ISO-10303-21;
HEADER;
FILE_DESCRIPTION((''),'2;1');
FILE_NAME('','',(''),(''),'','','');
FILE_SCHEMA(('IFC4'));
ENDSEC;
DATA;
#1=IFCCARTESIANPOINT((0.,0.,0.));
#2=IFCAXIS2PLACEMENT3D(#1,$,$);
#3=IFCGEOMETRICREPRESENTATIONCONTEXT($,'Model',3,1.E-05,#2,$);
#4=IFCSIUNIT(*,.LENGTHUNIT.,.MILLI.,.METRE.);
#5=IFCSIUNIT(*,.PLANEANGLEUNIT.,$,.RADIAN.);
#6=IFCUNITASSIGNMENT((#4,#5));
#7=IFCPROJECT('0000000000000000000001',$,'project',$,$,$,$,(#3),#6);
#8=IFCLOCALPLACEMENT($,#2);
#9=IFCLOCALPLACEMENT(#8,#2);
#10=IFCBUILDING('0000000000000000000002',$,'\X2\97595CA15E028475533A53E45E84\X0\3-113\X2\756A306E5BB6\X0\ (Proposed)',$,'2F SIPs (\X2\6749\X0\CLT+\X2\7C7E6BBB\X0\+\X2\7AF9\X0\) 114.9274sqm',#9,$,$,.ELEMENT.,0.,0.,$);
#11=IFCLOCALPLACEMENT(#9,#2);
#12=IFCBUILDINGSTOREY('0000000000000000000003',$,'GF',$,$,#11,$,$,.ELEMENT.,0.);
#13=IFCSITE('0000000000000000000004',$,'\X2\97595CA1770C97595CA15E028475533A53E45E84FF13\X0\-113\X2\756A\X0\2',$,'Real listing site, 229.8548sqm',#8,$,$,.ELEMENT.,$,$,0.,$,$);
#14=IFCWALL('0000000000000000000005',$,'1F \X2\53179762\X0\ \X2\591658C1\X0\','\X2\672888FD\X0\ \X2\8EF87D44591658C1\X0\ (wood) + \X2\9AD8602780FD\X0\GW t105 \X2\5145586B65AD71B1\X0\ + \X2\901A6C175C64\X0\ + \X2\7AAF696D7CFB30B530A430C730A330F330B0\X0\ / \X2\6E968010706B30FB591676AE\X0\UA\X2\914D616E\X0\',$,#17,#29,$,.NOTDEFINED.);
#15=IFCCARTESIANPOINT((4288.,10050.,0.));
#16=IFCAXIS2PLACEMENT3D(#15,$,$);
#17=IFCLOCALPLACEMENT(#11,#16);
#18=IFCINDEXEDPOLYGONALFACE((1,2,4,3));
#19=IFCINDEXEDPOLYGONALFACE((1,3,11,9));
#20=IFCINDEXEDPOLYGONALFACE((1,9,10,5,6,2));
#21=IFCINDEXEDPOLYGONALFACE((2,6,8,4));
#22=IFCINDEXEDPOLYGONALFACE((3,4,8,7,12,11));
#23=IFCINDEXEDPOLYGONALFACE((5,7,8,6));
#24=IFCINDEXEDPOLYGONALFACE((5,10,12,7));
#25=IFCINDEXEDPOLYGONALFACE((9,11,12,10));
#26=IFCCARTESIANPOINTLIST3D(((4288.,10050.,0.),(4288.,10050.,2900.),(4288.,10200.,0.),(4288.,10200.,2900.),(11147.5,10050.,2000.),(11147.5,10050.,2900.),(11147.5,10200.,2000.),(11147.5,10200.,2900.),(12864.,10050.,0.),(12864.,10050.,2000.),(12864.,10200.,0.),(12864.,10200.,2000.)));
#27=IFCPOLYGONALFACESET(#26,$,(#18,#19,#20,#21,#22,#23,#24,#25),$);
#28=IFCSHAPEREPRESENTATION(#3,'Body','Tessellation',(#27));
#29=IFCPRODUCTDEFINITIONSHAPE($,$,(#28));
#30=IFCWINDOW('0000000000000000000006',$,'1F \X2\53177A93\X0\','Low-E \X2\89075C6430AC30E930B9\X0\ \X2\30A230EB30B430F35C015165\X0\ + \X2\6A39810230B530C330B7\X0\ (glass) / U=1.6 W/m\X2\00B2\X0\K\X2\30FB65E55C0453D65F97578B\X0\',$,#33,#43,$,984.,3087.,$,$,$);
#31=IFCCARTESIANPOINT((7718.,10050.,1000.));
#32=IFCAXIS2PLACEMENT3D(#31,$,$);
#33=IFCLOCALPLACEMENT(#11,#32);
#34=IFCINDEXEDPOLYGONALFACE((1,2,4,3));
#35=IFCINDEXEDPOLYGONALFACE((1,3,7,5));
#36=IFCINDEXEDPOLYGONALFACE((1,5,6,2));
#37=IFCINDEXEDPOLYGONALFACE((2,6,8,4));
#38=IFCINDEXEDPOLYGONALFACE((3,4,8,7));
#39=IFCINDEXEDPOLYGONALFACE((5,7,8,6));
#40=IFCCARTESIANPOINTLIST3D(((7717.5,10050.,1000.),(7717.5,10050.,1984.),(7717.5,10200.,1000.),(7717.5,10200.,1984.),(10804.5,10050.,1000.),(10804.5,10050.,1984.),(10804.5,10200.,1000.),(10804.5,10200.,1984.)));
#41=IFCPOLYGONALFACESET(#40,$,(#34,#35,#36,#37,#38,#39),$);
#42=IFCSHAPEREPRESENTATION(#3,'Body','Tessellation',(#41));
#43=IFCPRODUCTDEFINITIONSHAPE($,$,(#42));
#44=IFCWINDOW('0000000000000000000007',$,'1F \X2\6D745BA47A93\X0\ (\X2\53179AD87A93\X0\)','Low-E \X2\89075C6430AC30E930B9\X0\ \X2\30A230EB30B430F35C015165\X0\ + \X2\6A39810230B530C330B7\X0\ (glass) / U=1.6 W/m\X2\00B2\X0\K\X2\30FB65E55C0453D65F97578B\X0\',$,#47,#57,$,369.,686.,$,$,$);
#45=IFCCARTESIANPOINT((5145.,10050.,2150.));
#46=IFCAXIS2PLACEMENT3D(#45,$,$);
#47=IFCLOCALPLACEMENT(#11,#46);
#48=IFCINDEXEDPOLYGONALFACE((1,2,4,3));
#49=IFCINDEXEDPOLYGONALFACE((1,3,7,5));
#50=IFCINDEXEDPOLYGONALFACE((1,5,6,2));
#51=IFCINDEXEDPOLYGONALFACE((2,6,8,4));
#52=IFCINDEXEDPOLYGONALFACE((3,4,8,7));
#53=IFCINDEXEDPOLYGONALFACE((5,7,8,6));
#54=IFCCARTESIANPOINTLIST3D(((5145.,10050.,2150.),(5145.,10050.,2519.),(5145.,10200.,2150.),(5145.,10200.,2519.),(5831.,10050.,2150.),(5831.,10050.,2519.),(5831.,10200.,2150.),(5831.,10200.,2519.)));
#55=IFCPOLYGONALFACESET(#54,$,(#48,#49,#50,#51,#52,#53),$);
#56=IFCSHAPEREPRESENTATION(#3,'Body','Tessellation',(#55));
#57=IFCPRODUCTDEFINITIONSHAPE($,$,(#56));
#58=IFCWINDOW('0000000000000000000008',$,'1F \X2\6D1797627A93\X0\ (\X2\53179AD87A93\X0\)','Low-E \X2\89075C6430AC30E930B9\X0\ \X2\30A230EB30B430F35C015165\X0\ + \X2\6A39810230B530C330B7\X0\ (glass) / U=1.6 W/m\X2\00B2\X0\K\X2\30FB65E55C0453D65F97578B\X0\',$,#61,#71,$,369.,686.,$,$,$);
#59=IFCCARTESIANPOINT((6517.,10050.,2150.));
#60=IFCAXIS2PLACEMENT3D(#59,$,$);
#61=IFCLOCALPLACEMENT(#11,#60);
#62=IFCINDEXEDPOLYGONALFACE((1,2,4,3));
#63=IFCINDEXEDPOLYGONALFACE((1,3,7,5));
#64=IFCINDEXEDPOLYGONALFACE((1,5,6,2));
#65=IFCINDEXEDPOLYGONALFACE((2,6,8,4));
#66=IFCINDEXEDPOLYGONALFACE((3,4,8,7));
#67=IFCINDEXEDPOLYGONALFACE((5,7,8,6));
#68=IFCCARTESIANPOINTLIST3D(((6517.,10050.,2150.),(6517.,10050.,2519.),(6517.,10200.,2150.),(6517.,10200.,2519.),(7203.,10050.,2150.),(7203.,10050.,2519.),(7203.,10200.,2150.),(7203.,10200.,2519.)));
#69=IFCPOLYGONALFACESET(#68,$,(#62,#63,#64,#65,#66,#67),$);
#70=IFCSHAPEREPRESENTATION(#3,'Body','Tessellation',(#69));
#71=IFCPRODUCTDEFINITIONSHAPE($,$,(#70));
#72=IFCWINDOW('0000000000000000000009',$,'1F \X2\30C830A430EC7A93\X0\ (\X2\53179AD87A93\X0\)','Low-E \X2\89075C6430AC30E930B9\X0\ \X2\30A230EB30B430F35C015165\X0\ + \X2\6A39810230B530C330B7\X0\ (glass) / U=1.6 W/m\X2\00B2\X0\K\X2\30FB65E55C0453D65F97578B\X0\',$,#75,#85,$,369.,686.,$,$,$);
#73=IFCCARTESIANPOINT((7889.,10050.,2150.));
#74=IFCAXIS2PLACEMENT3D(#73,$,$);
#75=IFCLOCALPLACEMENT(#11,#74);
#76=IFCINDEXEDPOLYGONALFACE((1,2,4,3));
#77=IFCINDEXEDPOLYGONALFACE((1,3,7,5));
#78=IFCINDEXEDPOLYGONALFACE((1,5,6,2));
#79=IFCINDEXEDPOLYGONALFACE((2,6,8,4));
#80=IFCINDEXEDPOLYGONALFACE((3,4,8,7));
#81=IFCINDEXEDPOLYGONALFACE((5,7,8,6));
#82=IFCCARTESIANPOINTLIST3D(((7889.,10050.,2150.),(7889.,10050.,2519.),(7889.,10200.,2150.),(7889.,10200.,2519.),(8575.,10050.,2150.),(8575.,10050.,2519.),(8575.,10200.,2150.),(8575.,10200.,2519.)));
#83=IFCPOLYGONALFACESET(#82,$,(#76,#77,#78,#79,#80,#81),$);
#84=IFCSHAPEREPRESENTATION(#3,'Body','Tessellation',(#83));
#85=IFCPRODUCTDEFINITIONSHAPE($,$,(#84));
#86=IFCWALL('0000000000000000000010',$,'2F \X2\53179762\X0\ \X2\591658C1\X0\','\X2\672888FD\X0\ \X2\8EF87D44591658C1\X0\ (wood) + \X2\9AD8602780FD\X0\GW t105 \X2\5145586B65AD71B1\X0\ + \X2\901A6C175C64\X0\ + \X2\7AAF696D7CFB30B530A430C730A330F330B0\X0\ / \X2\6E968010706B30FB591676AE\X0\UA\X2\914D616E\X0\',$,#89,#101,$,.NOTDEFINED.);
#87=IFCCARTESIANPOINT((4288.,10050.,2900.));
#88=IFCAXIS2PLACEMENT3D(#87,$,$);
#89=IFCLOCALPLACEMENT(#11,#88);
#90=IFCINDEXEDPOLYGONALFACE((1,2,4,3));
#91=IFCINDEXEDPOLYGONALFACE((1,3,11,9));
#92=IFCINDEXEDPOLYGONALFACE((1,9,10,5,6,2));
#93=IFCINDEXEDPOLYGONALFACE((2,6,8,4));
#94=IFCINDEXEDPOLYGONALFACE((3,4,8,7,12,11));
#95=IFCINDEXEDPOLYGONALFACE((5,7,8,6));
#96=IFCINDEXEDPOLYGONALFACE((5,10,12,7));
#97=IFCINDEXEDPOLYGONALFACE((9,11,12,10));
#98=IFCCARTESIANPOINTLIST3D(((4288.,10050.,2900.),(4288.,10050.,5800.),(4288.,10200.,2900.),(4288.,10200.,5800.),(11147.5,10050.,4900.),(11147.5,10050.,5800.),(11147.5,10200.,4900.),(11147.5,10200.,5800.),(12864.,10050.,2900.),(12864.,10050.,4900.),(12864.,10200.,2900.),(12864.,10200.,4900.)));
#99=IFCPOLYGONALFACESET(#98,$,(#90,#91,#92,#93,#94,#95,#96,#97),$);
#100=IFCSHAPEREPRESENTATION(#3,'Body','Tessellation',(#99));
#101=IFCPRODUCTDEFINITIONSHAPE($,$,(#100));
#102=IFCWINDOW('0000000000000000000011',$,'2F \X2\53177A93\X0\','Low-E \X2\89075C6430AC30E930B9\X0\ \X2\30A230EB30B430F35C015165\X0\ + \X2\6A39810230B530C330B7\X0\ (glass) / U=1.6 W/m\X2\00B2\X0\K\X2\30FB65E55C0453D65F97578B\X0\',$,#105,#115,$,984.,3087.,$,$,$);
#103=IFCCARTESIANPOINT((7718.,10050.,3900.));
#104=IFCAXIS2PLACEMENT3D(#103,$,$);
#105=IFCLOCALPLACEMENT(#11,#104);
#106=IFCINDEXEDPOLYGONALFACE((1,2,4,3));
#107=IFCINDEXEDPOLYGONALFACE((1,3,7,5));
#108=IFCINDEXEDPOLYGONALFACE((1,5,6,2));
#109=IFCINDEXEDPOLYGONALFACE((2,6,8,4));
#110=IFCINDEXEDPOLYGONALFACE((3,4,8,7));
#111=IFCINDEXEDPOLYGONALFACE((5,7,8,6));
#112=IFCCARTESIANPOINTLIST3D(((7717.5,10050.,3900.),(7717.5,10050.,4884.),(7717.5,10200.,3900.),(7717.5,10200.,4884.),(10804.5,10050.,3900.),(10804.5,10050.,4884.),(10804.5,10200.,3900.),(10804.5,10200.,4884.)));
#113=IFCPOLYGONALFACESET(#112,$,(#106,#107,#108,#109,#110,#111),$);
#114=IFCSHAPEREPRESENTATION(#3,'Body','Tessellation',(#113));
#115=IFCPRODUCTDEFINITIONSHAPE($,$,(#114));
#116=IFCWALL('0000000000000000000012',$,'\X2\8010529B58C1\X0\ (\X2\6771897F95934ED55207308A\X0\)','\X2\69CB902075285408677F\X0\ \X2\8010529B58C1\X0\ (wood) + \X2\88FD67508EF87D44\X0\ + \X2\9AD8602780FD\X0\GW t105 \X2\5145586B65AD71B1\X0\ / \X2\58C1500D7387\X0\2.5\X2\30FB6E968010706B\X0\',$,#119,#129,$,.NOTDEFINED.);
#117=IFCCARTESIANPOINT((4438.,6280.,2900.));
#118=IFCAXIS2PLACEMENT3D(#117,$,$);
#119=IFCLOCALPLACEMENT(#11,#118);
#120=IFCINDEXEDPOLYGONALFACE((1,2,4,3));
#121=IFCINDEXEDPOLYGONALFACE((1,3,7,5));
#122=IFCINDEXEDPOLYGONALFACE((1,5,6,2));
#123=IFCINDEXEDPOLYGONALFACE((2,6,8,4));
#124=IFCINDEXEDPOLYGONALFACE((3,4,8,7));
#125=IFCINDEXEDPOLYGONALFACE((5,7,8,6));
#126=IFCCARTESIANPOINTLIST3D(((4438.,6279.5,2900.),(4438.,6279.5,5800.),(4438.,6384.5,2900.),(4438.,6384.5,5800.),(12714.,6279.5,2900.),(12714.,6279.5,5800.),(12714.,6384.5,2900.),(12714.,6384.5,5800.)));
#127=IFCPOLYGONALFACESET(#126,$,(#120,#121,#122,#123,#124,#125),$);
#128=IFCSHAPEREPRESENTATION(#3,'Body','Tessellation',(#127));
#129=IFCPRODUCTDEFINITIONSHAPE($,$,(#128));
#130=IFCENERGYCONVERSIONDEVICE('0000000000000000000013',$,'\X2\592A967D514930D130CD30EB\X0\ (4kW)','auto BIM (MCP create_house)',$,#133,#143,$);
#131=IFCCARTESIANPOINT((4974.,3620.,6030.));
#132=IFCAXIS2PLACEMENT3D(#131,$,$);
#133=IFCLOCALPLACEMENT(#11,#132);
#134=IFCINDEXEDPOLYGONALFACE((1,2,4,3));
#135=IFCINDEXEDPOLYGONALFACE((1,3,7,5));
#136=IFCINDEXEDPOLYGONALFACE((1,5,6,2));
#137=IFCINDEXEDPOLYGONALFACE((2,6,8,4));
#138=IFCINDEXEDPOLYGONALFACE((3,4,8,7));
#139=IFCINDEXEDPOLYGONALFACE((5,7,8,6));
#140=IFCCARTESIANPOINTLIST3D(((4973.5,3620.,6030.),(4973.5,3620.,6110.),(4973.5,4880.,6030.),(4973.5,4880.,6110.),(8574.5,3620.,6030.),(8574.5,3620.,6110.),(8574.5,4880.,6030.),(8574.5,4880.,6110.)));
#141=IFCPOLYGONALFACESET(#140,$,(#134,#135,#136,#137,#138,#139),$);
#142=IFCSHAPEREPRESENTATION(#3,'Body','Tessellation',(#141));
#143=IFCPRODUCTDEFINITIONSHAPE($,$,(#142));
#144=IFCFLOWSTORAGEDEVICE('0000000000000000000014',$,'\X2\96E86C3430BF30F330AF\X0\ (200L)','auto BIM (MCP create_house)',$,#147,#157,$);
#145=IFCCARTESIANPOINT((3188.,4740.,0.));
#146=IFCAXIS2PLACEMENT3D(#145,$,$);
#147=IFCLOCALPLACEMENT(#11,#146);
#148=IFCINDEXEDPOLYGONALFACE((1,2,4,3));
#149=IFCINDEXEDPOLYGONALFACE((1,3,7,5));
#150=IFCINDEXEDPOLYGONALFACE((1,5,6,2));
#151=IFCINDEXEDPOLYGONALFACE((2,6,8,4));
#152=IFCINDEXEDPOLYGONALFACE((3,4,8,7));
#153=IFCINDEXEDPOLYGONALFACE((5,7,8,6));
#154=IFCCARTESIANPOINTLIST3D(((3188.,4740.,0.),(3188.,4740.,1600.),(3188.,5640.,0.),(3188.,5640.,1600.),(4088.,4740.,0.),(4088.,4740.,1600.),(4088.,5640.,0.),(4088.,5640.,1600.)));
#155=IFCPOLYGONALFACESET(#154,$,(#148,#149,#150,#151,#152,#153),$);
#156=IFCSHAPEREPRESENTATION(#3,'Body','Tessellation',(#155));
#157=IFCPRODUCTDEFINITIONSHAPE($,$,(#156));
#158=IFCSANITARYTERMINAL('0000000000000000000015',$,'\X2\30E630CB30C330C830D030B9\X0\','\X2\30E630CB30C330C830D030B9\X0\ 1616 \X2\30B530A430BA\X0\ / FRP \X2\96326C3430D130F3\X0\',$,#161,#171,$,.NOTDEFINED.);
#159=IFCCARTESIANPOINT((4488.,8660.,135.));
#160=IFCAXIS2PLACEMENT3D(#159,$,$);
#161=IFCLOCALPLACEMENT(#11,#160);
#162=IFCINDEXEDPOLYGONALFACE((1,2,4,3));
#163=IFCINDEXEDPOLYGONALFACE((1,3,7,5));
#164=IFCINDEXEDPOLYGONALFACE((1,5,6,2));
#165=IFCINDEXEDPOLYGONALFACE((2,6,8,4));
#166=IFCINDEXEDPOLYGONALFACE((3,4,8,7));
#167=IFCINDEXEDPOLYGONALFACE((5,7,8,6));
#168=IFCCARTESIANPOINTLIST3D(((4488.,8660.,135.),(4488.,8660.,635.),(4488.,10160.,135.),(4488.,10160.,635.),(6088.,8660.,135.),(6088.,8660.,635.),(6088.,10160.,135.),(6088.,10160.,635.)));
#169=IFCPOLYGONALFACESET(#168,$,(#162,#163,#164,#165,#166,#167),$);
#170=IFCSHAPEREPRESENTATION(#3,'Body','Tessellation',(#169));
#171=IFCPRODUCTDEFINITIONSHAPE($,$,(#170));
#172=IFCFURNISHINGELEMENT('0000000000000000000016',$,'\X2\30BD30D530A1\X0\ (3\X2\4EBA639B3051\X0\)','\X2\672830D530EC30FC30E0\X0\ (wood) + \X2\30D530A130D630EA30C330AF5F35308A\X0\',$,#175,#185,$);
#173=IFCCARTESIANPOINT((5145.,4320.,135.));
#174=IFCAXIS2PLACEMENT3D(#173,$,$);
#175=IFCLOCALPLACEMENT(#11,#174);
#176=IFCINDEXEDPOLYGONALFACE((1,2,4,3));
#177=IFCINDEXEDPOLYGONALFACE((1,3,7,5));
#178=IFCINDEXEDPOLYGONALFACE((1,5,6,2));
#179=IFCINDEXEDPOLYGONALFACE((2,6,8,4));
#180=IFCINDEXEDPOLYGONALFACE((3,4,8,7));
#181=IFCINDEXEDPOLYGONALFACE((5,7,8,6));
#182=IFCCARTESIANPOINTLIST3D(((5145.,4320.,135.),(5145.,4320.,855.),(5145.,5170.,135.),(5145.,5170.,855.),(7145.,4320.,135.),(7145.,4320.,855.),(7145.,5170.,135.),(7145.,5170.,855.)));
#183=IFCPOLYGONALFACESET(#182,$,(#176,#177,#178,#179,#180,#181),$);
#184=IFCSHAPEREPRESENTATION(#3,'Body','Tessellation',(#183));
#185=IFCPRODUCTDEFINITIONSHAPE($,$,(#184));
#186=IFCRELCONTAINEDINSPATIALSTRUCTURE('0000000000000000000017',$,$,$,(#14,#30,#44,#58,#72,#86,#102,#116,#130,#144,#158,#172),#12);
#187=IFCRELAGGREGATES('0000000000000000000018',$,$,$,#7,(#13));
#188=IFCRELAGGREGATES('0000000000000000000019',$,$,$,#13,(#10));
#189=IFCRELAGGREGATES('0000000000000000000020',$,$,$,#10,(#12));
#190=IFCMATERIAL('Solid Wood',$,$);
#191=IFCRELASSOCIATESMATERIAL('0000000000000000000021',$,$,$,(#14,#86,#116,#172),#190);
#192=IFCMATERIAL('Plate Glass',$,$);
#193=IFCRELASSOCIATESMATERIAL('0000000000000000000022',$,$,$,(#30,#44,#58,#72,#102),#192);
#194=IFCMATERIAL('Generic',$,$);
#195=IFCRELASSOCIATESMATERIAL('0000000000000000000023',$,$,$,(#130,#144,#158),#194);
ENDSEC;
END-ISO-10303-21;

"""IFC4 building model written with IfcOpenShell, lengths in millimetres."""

from ifc_helpers import new_model, si_unit, frame, frame_2d, origin, place, context, project, spatial, rectangle, extrude, material, element, fill, save


model = new_model("IFC4")

# Units and contexts
model_context = context("Model", 3, precision=1e-05, world=origin())
ifc_project = project(units=[si_unit("LENGTHUNIT", "METRE", prefix="MILLI"), si_unit("PLANEANGLEUNIT", "RADIAN")], contexts=[model_context])

# Site, building, storey
site_placement = place(None, origin())
site = spatial("IfcSite", under=ifc_project, at=site_placement, Name="静岡県静岡市葵区古庄３-113番2", ObjectType="Real listing site, 229.8548sqm", CompositionType="ELEMENT", RefElevation=0.0)
building_placement = place(site_placement, origin())
building = spatial("IfcBuilding", under=site, at=building_placement, Name="静岡市葵区古庄3-113番の家 (Proposed)", ObjectType="2F SIPs (杉CLT+籾殻+竹) 114.9274sqm", CompositionType="ELEMENT", ElevationOfRefHeight=0.0, ElevationOfTerrain=0.0)
storey_placement = place(building_placement, origin())
storey = spatial("IfcBuildingStorey", under=building, at=storey_placement, Name="GF", CompositionType="ELEMENT", Elevation=0.0)

# Wall, openings, windows
ifc_material_1 = material(Name="Solid Wood")
wall_1_placement = place(storey_placement, frame((4288.0, 10050.0, 0.0)))
wall_1 = element("IfcWall", 1, at=wall_1_placement, inside=storey, material=ifc_material_1, Name="1F 北面 外壁", Description="木製 軸組外壁 (wood) + 高性能GW t105 充填断熱 + 通気層 + 窯業系サイディング / 準耐火・外皮UA配慮", PredefinedType="NOTDEFINED", context=model_context, shape_type="SweptSolid", body=[
    extrude(rectangle(XDim=8576.0, YDim=150.0, at=frame_2d((4288.0, 75.0))), frame((4288.0, 10050.0, 0.0)), (0.0, 0.0, 1.0), 2900.0),
])
opening_1_placement = place(storey_placement, frame((7718.0, 10050.0, 1000.0)))
opening_1 = element("IfcOpeningElement", 2, at=opening_1_placement, cuts=wall_1, PredefinedType="NOTDEFINED", context=model_context, shape_type="SweptSolid", body=[
    extrude(rectangle(XDim=3087.0, YDim=150.0, at=frame_2d((1543.0, 75.0))), frame((7718.0, 10050.0, 1000.0)), (0.0, 0.0, 1.0), 984.0),
])
opening_2_placement = place(storey_placement, frame((5145.0, 10050.0, 2150.0)))
opening_2 = element("IfcOpeningElement", 3, at=opening_2_placement, cuts=wall_1, PredefinedType="NOTDEFINED", context=model_context, shape_type="SweptSolid", body=[
    extrude(rectangle(XDim=686.0, YDim=150.0, at=frame_2d((343.0, 75.0))), frame((5145.0, 10050.0, 2150.0)), (0.0, 0.0, 1.0), 369.0),
])
opening_3_placement = place(storey_placement, frame((6517.0, 10050.0, 2150.0)))
opening_3 = element("IfcOpeningElement", 4, at=opening_3_placement, cuts=wall_1, PredefinedType="NOTDEFINED", context=model_context, shape_type="SweptSolid", body=[
    extrude(rectangle(XDim=686.0, YDim=150.0, at=frame_2d((343.0, 75.0))), frame((6517.0, 10050.0, 2150.0)), (0.0, 0.0, 1.0), 369.0),
])
opening_4_placement = place(storey_placement, frame((7889.0, 10050.0, 2150.0)))
opening_4 = element("IfcOpeningElement", 5, at=opening_4_placement, cuts=wall_1, PredefinedType="NOTDEFINED", context=model_context, shape_type="SweptSolid", body=[
    extrude(rectangle(XDim=686.0, YDim=150.0, at=frame_2d((343.0, 75.0))), frame((7889.0, 10050.0, 2150.0)), (0.0, 0.0, 1.0), 369.0),
])
ifc_material_2 = material(Name="Plate Glass")
window_1_placement = place(storey_placement, frame((7718.0, 10050.0, 1000.0)))
window_1 = element("IfcWindow", 6, at=window_1_placement, inside=storey, material=ifc_material_2, Name="1F 北窓", Description="Low-E 複層ガラス アルゴン封入 + 樹脂サッシ (glass) / U=1.6 W/m²K・日射取得型", OverallHeight=984.0, OverallWidth=3087.0, context=model_context, shape_type="SweptSolid", body=[
    extrude(rectangle(XDim=3087.0, YDim=150.0, at=frame_2d((1543.0, 75.0))), frame((7718.0, 10050.0, 1000.0)), (0.0, 0.0, 1.0), 984.0),
])
fill(opening_1, window_1)
window_2_placement = place(storey_placement, frame((5145.0, 10050.0, 2150.0)))
window_2 = element("IfcWindow", 7, at=window_2_placement, inside=storey, material=ifc_material_2, Name="1F 浴室窓 (北高窓)", Description="Low-E 複層ガラス アルゴン封入 + 樹脂サッシ (glass) / U=1.6 W/m²K・日射取得型", OverallHeight=369.0, OverallWidth=686.0, context=model_context, shape_type="SweptSolid", body=[
    extrude(rectangle(XDim=686.0, YDim=150.0, at=frame_2d((343.0, 75.0))), frame((5145.0, 10050.0, 2150.0)), (0.0, 0.0, 1.0), 369.0),
])
fill(opening_2, window_2)
window_3_placement = place(storey_placement, frame((6517.0, 10050.0, 2150.0)))
window_3 = element("IfcWindow", 8, at=window_3_placement, inside=storey, material=ifc_material_2, Name="1F 洗面窓 (北高窓)", Description="Low-E 複層ガラス アルゴン封入 + 樹脂サッシ (glass) / U=1.6 W/m²K・日射取得型", OverallHeight=369.0, OverallWidth=686.0, context=model_context, shape_type="SweptSolid", body=[
    extrude(rectangle(XDim=686.0, YDim=150.0, at=frame_2d((343.0, 75.0))), frame((6517.0, 10050.0, 2150.0)), (0.0, 0.0, 1.0), 369.0),
])
fill(opening_3, window_3)
window_4_placement = place(storey_placement, frame((7889.0, 10050.0, 2150.0)))
window_4 = element("IfcWindow", 9, at=window_4_placement, inside=storey, material=ifc_material_2, Name="1F トイレ窓 (北高窓)", Description="Low-E 複層ガラス アルゴン封入 + 樹脂サッシ (glass) / U=1.6 W/m²K・日射取得型", OverallHeight=369.0, OverallWidth=686.0, context=model_context, shape_type="SweptSolid", body=[
    extrude(rectangle(XDim=686.0, YDim=150.0, at=frame_2d((343.0, 75.0))), frame((7889.0, 10050.0, 2150.0)), (0.0, 0.0, 1.0), 369.0),
])
fill(opening_4, window_4)

# Wall, opening, window
wall_2_placement = place(storey_placement, frame((4288.0, 10050.0, 2900.0)))
wall_2 = element("IfcWall", 10, at=wall_2_placement, inside=storey, material=ifc_material_1, Name="2F 北面 外壁", Description="木製 軸組外壁 (wood) + 高性能GW t105 充填断熱 + 通気層 + 窯業系サイディング / 準耐火・外皮UA配慮", PredefinedType="NOTDEFINED", context=model_context, shape_type="SweptSolid", body=[
    extrude(rectangle(XDim=8576.0, YDim=150.0, at=frame_2d((4288.0, 75.0))), frame((4288.0, 10050.0, 2900.0)), (0.0, 0.0, 1.0), 2900.0),
])
opening_5_placement = place(storey_placement, frame((7718.0, 10050.0, 3900.0)))
opening_5 = element("IfcOpeningElement", 11, at=opening_5_placement, cuts=wall_2, PredefinedType="NOTDEFINED", context=model_context, shape_type="SweptSolid", body=[
    extrude(rectangle(XDim=3087.0, YDim=150.0, at=frame_2d((1543.0, 75.0))), frame((7718.0, 10050.0, 3900.0)), (0.0, 0.0, 1.0), 984.0),
])
window_5_placement = place(storey_placement, frame((7718.0, 10050.0, 3900.0)))
window_5 = element("IfcWindow", 12, at=window_5_placement, inside=storey, material=ifc_material_2, Name="2F 北窓", Description="Low-E 複層ガラス アルゴン封入 + 樹脂サッシ (glass) / U=1.6 W/m²K・日射取得型", OverallHeight=984.0, OverallWidth=3087.0, context=model_context, shape_type="SweptSolid", body=[
    extrude(rectangle(XDim=3087.0, YDim=150.0, at=frame_2d((1543.0, 75.0))), frame((7718.0, 10050.0, 3900.0)), (0.0, 0.0, 1.0), 984.0),
])
fill(opening_5, window_5)

# Wall
wall_3_placement = place(storey_placement, frame((4438.0, 6280.0, 2900.0)))
element("IfcWall", 13, at=wall_3_placement, inside=storey, material=ifc_material_1, Name="耐力壁 (東西間仕切り)", Description="構造用合板 耐力壁 (wood) + 製材軸組 + 高性能GW t105 充填断熱 / 壁倍率2.5・準耐火", PredefinedType="NOTDEFINED", context=model_context, shape_type="SweptSolid", body=[
    extrude(rectangle(XDim=8276.0, YDim=105.0, at=frame_2d((4138.0, 52.0))), frame((4438.0, 6280.0, 2900.0)), (0.0, 0.0, 1.0), 2900.0),
])

# Energy conversion device
ifc_material_3 = material(Name="Generic")
energy_conversion_device_placement = place(storey_placement, frame((4974.0, 3620.0, 6030.0)))
element("IfcEnergyConversionDevice", 14, at=energy_conversion_device_placement, inside=storey, material=ifc_material_3, Name="太陽光パネル (4kW)", Description="auto BIM (MCP create_house)", context=model_context, shape_type="SweptSolid", body=[
    extrude(rectangle(XDim=3601.0, YDim=1260.0, at=frame_2d((1800.0, 630.0))), frame((4974.0, 3620.0, 6030.0)), (0.0, 0.0, 1.0), 80.0),
])

# Flow storage device
flow_storage_device_placement = place(storey_placement, frame((3188.0, 4740.0, 0.0)))
element("IfcFlowStorageDevice", 15, at=flow_storage_device_placement, inside=storey, material=ifc_material_3, Name="雨水タンク (200L)", Description="auto BIM (MCP create_house)", context=model_context, shape_type="SweptSolid", body=[
    extrude(rectangle(XDim=900.0, YDim=900.0, at=frame_2d((450.0, 450.0))), frame((3188.0, 4740.0, 0.0)), (0.0, 0.0, 1.0), 1600.0),
])

# Sanitary terminal
sanitary_terminal_placement = place(storey_placement, frame((4488.0, 8660.0, 135.0)))
element("IfcSanitaryTerminal", 16, at=sanitary_terminal_placement, inside=storey, material=ifc_material_3, Name="ユニットバス", Description="ユニットバス 1616 サイズ / FRP 防水パン", PredefinedType="NOTDEFINED", context=model_context, shape_type="SweptSolid", body=[
    extrude(rectangle(XDim=1600.0, YDim=1500.0, at=frame_2d((800.0, 750.0))), frame((4488.0, 8660.0, 135.0)), (0.0, 0.0, 1.0), 500.0),
])

# Furnishing element
furnishing_1_placement = place(storey_placement, frame((5145.0, 4320.0, 135.0)))
element("IfcFurnishingElement", 17, at=furnishing_1_placement, inside=storey, material=ifc_material_1, Name="ソファ (3人掛け)", Description="木フレーム (wood) + ファブリック張り", context=model_context, shape_type="SweptSolid", body=[
    extrude(rectangle(XDim=2000.0, YDim=850.0, at=frame_2d((1000.0, 425.0))), frame((5145.0, 4320.0, 135.0)), (0.0, 0.0, 1.0), 720.0),
])

save(model, "model.ifc")
